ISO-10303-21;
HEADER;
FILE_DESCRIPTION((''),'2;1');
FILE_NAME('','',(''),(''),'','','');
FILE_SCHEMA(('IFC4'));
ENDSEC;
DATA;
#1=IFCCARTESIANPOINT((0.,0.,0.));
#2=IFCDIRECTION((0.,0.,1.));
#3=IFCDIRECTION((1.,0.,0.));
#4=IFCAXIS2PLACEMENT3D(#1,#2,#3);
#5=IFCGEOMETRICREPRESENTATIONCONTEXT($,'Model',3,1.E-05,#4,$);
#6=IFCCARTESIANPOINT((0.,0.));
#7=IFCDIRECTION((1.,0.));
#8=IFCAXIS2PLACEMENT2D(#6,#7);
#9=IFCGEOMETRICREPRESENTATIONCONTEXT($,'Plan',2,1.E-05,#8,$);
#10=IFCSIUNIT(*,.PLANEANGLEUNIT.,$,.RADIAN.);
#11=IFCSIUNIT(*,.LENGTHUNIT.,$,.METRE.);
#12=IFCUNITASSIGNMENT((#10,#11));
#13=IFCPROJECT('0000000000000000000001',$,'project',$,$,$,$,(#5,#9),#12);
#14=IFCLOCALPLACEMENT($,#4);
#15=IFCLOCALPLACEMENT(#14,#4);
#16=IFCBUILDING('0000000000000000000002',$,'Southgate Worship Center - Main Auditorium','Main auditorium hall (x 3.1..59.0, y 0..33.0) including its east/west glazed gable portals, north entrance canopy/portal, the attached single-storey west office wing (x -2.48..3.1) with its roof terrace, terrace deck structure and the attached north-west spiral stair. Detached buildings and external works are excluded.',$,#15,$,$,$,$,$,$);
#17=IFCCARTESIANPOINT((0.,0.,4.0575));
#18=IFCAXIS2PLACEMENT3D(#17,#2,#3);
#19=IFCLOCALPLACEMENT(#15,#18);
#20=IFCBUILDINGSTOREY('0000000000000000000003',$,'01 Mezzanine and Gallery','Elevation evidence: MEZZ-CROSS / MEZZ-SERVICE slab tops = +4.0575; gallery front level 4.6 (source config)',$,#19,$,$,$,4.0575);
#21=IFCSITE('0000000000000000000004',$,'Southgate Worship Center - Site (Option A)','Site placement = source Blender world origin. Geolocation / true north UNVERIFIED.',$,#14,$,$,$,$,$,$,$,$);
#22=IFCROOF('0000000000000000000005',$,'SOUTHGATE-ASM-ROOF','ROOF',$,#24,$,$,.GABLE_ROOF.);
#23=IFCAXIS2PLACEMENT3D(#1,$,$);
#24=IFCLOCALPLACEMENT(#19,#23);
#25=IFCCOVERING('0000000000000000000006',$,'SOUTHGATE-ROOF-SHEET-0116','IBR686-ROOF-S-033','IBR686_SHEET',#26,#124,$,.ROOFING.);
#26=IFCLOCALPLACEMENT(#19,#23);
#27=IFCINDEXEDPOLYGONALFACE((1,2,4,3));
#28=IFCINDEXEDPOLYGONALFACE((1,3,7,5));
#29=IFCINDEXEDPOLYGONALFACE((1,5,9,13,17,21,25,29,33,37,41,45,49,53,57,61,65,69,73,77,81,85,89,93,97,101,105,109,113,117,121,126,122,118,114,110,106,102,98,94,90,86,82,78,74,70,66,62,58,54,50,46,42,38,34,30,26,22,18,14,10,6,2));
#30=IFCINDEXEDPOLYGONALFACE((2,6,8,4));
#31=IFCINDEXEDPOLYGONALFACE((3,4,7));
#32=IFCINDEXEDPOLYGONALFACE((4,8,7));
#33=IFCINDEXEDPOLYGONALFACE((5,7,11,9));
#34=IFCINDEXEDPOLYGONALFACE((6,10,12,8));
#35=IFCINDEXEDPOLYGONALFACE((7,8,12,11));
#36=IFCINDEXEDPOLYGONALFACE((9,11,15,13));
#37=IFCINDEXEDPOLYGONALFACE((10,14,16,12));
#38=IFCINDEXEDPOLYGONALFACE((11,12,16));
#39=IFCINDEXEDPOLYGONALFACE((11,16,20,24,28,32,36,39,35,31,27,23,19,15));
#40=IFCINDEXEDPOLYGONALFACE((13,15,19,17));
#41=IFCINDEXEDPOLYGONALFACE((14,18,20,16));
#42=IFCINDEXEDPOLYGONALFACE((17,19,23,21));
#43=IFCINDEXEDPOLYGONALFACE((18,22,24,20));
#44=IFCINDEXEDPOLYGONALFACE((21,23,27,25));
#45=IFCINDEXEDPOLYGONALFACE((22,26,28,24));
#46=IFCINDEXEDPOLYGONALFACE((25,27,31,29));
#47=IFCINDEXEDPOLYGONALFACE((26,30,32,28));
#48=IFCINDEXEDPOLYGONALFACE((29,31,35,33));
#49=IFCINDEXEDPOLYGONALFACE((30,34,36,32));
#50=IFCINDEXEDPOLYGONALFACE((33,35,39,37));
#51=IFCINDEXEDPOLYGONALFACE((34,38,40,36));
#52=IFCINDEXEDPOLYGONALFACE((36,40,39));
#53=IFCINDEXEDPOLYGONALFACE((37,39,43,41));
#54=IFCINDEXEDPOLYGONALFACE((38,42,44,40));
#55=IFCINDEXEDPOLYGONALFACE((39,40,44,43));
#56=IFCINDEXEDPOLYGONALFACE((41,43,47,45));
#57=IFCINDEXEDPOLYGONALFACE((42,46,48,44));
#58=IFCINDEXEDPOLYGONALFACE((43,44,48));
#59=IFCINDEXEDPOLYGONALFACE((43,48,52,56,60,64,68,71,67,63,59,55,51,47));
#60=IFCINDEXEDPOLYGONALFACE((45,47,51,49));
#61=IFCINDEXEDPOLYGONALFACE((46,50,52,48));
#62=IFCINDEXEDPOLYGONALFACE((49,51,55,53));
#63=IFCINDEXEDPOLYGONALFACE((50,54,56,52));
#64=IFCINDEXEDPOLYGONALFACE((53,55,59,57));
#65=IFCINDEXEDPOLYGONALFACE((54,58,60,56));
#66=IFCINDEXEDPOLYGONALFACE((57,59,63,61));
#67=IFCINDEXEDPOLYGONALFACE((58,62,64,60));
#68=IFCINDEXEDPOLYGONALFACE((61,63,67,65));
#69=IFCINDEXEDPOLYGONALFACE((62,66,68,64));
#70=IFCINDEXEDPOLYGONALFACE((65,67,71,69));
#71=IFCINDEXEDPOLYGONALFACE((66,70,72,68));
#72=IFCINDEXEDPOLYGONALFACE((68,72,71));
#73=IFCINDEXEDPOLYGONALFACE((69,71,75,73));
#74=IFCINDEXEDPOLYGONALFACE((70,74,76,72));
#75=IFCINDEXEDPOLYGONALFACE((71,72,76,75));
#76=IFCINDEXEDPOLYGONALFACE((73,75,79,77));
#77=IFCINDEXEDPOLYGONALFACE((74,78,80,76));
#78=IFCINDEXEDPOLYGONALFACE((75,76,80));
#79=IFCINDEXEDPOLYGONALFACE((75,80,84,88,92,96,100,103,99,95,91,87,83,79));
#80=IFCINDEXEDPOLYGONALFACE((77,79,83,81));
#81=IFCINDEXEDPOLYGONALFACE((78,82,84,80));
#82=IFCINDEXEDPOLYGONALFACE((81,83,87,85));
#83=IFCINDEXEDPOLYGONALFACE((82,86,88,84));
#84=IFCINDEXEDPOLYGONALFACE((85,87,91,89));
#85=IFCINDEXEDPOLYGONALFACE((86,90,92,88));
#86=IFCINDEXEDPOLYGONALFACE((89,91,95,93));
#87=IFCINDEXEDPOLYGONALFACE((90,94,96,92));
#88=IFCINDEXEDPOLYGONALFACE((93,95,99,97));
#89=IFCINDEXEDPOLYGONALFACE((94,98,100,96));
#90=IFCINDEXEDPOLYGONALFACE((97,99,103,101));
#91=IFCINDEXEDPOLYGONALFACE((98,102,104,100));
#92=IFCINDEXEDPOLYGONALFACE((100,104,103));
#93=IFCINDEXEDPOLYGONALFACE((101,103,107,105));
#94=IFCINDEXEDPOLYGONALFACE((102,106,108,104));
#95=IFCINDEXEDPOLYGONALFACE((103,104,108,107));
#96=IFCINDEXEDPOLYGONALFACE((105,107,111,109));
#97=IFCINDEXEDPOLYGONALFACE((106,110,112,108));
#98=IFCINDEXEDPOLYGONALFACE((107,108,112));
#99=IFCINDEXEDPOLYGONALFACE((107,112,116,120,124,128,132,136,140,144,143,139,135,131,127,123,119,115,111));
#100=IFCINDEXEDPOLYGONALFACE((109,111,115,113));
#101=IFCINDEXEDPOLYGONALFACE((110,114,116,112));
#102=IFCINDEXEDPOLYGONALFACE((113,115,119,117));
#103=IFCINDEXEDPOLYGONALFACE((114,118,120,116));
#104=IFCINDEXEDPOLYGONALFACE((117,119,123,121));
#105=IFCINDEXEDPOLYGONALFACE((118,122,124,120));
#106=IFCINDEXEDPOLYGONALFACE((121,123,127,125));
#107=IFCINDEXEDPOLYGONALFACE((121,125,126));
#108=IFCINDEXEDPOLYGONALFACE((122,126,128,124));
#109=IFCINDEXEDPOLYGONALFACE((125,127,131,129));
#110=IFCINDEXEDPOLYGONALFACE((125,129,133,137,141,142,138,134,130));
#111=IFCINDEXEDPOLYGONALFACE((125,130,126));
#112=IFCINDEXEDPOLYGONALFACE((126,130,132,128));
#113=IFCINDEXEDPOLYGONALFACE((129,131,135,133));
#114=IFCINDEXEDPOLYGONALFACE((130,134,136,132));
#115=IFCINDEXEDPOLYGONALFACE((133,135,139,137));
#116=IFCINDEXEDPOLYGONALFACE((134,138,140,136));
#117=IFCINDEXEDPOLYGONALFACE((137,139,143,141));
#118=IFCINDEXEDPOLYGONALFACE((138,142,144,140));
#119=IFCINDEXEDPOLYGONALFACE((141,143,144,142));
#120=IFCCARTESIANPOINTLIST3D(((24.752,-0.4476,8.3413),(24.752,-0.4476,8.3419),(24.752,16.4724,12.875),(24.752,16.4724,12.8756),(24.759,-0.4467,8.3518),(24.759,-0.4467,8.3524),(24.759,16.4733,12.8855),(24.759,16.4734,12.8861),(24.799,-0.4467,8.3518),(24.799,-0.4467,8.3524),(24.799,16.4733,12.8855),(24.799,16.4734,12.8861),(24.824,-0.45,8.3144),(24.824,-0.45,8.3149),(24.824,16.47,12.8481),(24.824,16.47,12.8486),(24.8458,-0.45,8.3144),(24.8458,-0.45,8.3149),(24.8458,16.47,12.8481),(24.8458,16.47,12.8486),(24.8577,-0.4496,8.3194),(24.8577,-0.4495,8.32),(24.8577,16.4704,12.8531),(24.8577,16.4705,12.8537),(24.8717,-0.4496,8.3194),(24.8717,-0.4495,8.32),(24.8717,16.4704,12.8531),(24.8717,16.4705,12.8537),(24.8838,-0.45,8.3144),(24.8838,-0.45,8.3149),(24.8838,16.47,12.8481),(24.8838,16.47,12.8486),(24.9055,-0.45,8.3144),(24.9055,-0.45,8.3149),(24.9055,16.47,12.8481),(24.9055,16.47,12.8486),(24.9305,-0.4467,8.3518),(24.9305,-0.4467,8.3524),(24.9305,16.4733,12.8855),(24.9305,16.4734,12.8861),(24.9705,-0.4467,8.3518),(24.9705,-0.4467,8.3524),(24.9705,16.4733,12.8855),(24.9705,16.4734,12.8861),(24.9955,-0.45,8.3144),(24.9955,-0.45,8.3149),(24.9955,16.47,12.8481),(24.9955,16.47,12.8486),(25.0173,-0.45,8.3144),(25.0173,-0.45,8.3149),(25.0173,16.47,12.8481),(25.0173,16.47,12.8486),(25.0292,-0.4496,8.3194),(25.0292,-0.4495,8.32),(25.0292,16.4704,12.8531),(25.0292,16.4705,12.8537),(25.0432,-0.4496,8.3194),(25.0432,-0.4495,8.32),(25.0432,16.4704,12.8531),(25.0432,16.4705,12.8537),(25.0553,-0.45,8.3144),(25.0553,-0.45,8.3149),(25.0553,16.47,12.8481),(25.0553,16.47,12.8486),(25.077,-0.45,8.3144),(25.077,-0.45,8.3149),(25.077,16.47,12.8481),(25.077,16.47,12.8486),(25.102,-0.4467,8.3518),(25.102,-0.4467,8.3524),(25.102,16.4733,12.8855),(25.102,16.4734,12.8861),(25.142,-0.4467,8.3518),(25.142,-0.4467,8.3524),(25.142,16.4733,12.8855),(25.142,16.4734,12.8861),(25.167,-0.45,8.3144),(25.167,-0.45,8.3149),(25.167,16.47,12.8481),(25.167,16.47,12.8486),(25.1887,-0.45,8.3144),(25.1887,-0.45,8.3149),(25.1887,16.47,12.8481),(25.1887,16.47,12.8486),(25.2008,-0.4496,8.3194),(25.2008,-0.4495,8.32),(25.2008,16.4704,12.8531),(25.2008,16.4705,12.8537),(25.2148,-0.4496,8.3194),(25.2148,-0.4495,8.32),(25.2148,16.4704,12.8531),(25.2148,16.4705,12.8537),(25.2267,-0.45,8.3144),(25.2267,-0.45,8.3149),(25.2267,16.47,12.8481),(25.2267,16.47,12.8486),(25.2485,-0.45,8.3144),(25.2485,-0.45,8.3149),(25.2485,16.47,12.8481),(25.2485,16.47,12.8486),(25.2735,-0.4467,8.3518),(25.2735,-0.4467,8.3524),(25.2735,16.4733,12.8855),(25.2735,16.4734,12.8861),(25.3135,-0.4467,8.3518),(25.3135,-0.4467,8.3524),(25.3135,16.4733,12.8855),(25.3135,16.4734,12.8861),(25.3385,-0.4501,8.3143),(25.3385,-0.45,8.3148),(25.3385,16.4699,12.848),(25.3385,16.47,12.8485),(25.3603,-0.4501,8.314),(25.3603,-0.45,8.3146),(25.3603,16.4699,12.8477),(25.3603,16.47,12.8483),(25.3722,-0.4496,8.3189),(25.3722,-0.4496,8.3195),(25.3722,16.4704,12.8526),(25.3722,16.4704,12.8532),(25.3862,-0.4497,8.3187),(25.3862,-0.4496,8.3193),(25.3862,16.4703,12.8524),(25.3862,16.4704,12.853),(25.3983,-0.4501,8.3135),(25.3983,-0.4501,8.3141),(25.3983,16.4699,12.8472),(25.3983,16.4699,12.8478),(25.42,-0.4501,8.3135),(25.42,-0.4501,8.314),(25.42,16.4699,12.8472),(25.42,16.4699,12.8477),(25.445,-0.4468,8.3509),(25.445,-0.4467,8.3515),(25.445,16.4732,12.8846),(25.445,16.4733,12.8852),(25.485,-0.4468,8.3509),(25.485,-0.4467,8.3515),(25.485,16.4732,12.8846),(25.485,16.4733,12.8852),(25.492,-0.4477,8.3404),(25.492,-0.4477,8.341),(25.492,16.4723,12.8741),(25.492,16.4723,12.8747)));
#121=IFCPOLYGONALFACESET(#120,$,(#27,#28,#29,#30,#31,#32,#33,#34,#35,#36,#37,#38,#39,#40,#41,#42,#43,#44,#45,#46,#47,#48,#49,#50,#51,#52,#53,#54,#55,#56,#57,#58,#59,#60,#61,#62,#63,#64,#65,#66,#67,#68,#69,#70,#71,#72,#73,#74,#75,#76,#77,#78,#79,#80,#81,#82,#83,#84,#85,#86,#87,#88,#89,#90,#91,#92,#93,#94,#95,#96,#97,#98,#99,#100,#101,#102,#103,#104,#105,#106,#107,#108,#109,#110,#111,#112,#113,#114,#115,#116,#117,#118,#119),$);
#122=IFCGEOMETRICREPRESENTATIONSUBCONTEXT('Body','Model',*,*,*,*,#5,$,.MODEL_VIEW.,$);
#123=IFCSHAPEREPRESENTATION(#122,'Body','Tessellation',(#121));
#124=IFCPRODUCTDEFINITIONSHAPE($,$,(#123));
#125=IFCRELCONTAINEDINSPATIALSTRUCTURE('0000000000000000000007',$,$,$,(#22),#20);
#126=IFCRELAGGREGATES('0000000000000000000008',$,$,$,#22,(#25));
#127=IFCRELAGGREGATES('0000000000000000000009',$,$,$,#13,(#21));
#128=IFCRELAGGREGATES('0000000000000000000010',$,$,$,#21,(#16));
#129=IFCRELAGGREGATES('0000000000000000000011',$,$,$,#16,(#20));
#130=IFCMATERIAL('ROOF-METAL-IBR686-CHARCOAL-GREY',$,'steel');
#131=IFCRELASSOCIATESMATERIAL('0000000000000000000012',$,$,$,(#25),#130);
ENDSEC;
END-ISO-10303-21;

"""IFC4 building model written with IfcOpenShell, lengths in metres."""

from ifc_helpers import new_model, si_unit, frame, origin_with_axes, origin_2d_with_axis, place, context, subcontext, project, spatial, indexed_curve, outline, extrude, clip, halfspace, material, element, aggregate, save


model = new_model("IFC4")

# Units and contexts
model_context = context("Model", 3, precision=1e-05, world=origin_with_axes())
plan_context = context("Plan", 2, precision=1e-05, world=origin_2d_with_axis())
body_context = subcontext(model_context, "Body", "Model", "MODEL_VIEW")
ifc_project = project(units=[si_unit("PLANEANGLEUNIT", "RADIAN"), si_unit("LENGTHUNIT", "METRE")], contexts=[model_context, plan_context])

# Site, building, storey
site_placement = place(None, origin_with_axes())
site = spatial("IfcSite", under=ifc_project, at=site_placement, Name="Southgate Worship Center - Site (Option A)", Description="Site placement = source Blender world origin. Geolocation / true north UNVERIFIED.")
building_placement = place(site_placement, origin_with_axes())
building = spatial("IfcBuilding", under=site, at=building_placement, Name="Southgate Worship Center - Main Auditorium", Description="Main auditorium hall (x 3.1..59.0, y 0..33.0) including its east/west glazed gable portals, north entrance canopy/portal, the attached single-storey west office wing (x -2.48..3.1) with its roof terrace, terrace deck structure and the attached north-west spiral stair. Detached buildings and external works are excluded.")
storey_placement = place(building_placement, frame((0.0, 0.0, 4.0575), z_axis=(0.0, 0.0, 1.0), x_axis=(1.0, 0.0, 0.0)))
storey = spatial("IfcBuildingStorey", under=building, at=storey_placement, Name="01 Mezzanine and Gallery", Description="Elevation evidence: MEZZ-CROSS / MEZZ-SERVICE slab tops = +4.0575; gallery front level 4.6 (source config)", Elevation=4.0575)

# Roof, covering
roof_placement = place(storey_placement, origin_with_axes())
roof = element("IfcRoof", 1, at=roof_placement, inside=storey, Name="SOUTHGATE-ASM-ROOF", Description="ROOF", PredefinedType="GABLE_ROOF")
ifc_material_1 = material(Name="ROOF-METAL-IBR686-CHARCOAL-GREY", Category="steel")
covering_1_placement = place(roof_placement, frame((24.752, -0.4501, 8.3135), z_axis=(0.0, 0.0, 1.0), x_axis=(1.0, 0.0, 0.0)))
covering_1 = element("IfcCovering", 2, at=covering_1_placement, material=ifc_material_1, Name="SOUTHGATE-ROOF-SHEET-0116", Description="IBR686-ROOF-S-033", ObjectType="IBR686_SHEET", PredefinedType="ROOFING", context=body_context, shape_type="Clipping", body=[
    clip(clip(extrude(outline(indexed_curve([(0.0, 0.0), (0.025, 0.0353), (0.065, 0.0353), (0.072, 0.0254), (0.072, 0.0259), (0.065, 0.0358), (0.025, 0.0358), (0.0, 0.0005), (-0.0218, 0.0005), (-0.0338, 0.0053), (-0.0478, 0.0053), (-0.0598, 0.0005), (-0.0815, 0.0005), (-0.1065, 0.0358), (-0.1465, 0.0358), (-0.1715, 0.0005), (-0.1933, 0.0005), (-0.2052, 0.0053), (-0.2192, 0.0053), (-0.2313, 0.0005), (-0.253, 0.0005), (-0.278, 0.0358), (-0.318, 0.0358), (-0.343, 0.0005), (-0.3647, 0.0005), (-0.3768, 0.0053), (-0.3908, 0.0053), (-0.4028, 0.0005), (-0.4245, 0.0005), (-0.4495, 0.0358), (-0.4895, 0.0358), (-0.5145, 0.0004), (-0.5363, 0.0002), (-0.5483, 0.0048), (-0.5623, 0.0046), (-0.5743, -0.0003), (-0.596, -0.0004), (-0.621, 0.0349), (-0.661, 0.0349), (-0.668, 0.0251), (-0.668, 0.0246), (-0.661, 0.0344), (-0.621, 0.0344), (-0.596, -0.0009), (-0.5743, -0.0008), (-0.5623, 0.0041), (-0.5483, 0.0043), (-0.5363, -0.0003), (-0.5145, -0.0001), (-0.4895, 0.0353), (-0.4495, 0.0353), (-0.4245, 0.0), (-0.4028, 0.0), (-0.3908, 0.0048), (-0.3768, 0.0048), (-0.3647, 0.0), (-0.343, 0.0), (-0.318, 0.0353), (-0.278, 0.0353), (-0.253, 0.0), (-0.2313, 0.0), (-0.2192, 0.0048), (-0.2052, 0.0048), (-0.1933, 0.0), (-0.1715, 0.0), (-0.1465, 0.0353), (-0.1065, 0.0353), (-0.0815, 0.0), (-0.0598, 0.0), (-0.0478, 0.0048), (-0.0338, 0.0048), (-0.0218, 0.0), (0.0, 0.0)], self_intersect=False)), frame((0.072, -0.0003, 0.0008), z_axis=(0.0, 0.965926, 0.258819), x_axis=(-1.0, 0.0, 0.0)), (0.0, 0.0, 1.0), 17.5303), halfspace(frame((0.37, 0.0012, 0.014), z_axis=(0.0, -0.996022, 0.089113), x_axis=(1.0, 0.0, 0.0)), False)), halfspace(frame((0.37, 16.9212, 4.5477), z_axis=(0.0, 0.996021, -0.089119), x_axis=(-1.0, 0.0, 0.0)), False)),
])
aggregate(roof, [covering_1])

save(model, "model.ifc")
